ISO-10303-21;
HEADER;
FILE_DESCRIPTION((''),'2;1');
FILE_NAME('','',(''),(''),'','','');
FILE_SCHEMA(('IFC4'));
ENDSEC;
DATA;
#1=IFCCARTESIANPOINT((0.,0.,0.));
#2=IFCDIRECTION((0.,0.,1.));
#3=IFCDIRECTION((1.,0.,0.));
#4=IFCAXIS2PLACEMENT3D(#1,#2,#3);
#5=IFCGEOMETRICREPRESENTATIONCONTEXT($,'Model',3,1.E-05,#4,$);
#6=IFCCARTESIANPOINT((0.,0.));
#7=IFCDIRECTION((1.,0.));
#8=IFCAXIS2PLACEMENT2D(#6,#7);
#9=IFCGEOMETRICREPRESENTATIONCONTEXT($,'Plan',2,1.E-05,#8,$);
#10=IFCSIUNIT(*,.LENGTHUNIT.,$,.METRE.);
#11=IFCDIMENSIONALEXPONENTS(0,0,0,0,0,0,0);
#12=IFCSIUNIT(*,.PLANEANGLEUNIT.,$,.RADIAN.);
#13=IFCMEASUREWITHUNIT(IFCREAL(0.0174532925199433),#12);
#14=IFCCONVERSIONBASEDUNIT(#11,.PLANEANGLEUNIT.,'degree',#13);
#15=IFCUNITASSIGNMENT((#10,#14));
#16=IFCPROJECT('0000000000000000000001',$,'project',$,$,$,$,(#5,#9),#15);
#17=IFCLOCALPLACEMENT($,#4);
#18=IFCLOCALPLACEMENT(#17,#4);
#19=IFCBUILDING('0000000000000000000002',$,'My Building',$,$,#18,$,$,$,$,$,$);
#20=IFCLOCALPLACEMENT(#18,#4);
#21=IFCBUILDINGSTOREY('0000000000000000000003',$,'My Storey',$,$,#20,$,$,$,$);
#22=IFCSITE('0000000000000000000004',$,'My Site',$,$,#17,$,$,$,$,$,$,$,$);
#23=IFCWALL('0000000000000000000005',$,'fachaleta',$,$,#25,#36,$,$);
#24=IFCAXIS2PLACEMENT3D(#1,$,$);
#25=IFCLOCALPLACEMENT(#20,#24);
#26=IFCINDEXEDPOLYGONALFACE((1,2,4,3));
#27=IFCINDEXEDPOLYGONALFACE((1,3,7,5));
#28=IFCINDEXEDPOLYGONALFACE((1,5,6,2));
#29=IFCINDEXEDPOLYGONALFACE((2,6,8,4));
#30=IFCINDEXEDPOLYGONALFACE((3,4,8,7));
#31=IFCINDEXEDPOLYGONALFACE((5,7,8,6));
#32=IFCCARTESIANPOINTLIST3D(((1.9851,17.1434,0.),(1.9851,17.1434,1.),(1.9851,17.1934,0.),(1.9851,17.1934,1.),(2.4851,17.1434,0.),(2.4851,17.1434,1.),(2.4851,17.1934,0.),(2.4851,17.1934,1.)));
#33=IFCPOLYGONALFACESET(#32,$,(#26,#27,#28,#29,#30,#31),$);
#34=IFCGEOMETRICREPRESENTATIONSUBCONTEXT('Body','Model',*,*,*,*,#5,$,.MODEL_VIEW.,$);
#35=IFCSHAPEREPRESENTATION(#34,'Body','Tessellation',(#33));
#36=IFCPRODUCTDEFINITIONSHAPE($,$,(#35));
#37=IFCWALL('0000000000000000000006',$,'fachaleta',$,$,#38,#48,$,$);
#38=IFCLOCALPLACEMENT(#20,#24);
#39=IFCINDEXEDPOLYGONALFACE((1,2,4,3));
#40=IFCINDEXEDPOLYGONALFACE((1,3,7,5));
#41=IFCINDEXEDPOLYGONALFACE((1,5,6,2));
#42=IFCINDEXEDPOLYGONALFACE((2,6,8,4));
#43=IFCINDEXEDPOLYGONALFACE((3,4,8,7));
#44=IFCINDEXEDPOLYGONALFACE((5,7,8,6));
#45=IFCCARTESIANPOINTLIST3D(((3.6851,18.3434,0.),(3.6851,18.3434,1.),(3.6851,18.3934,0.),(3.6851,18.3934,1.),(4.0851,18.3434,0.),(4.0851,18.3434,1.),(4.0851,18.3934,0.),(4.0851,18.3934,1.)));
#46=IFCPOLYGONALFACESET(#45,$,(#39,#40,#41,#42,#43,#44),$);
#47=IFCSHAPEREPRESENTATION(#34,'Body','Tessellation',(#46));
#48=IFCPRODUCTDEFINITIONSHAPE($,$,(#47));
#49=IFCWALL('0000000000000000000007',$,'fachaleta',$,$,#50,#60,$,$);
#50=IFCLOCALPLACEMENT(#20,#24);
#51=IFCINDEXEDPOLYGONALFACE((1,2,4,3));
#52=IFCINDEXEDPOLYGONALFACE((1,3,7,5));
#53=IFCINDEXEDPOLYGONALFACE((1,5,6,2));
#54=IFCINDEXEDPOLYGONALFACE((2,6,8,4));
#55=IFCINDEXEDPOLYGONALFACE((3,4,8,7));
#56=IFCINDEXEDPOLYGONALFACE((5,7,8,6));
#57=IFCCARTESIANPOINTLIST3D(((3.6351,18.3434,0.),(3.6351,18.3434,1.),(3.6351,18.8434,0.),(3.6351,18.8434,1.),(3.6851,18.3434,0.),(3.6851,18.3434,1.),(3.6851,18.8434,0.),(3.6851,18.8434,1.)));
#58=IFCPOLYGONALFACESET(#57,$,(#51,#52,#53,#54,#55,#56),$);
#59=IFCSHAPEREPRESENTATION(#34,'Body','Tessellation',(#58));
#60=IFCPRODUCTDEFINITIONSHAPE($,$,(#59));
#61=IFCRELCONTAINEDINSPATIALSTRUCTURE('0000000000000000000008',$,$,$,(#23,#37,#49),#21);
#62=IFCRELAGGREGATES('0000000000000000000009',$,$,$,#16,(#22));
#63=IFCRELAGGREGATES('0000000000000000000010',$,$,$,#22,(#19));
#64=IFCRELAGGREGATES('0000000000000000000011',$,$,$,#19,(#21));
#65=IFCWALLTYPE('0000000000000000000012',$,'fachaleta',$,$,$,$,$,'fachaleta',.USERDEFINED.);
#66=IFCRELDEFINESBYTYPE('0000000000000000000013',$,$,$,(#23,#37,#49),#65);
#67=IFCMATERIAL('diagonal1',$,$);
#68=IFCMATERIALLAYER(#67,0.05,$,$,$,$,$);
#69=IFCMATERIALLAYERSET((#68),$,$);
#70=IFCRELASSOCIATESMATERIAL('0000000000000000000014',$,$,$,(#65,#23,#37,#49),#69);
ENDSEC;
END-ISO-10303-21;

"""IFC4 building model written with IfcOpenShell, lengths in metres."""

from ifc_helpers import new_model, entity, si_unit, converted_unit, frame, origin_with_axes, origin_2d_with_axis, place, context, subcontext, project, spatial, indexed_curve, outline, extrude, material, layer, layer_set, layer_usage, type_object, element, save


model = new_model("IFC4")

# Units and contexts
model_context = context("Model", 3, precision=1e-05, world=origin_with_axes())
plan_context = context("Plan", 2, precision=1e-05, world=origin_2d_with_axis())
body_context = subcontext(model_context, "Body", "Model", "MODEL_VIEW")
ifc_project = project(units=[si_unit("LENGTHUNIT", "METRE"), converted_unit("PLANEANGLEUNIT", "degree", entity("IfcReal", 0.0174532925199433), si_unit("PLANEANGLEUNIT", "RADIAN"), dimensions=[0, 0, 0, 0, 0, 0, 0])], contexts=[model_context, plan_context])

# Site, building, storey
site_placement = place(None, origin_with_axes())
site = spatial("IfcSite", under=ifc_project, at=site_placement, Name="My Site")
building_placement = place(site_placement, origin_with_axes())
building = spatial("IfcBuilding", under=site, at=building_placement, Name="My Building")
storey_placement = place(building_placement, origin_with_axes())
storey = spatial("IfcBuildingStorey", under=building, at=storey_placement, Name="My Storey")

# Walls
ifc_material_1 = material(Name="diagonal1")
ifc_layer = layer(ifc_material_1, 0.05)
ifc_layer_set = layer_set([ifc_layer])
wall_type = type_object("IfcWallType", Name="fachaleta", ElementType="fachaleta", PredefinedType="USERDEFINED", material=ifc_layer_set)
ifc_layer_usage_1 = layer_usage(ifc_layer_set, "AXIS2", "POSITIVE", 0.0)
wall_1_placement = place(storey_placement, frame((2.4851, 17.1934, 0.0), z_axis=(0.0, 0.0, 1.0), x_axis=(-1.0, 0.0, 0.0)))
element("IfcWall", 1, at=wall_1_placement, inside=storey, type_object=wall_type, material=ifc_layer_usage_1, Name="fachaleta", context=body_context, shape_type="SweptSolid", body=[
    extrude(outline(indexed_curve([(0.0, 0.0), (0.0, 0.05), (0.5, 0.05), (0.5, 0.0), (0.0, 0.0)], self_intersect=False)), origin_with_axes(), (0.0, 0.0, 1.0), 1.0),
])
ifc_layer_usage_2 = layer_usage(ifc_layer_set, "AXIS2", "POSITIVE", 0.0)
wall_2_placement = place(storey_placement, frame((3.6851, 18.3434, 0.0), z_axis=(0.0, 0.0, 1.0), x_axis=(1.0, 0.0, 0.0)))
element("IfcWall", 2, at=wall_2_placement, inside=storey, type_object=wall_type, material=ifc_layer_usage_2, Name="fachaleta", context=body_context, shape_type="SweptSolid", body=[
    extrude(outline(indexed_curve([(0.0, 0.0), (0.0, 0.05), (0.4, 0.05), (0.4, 0.0), (0.0, 0.0)], self_intersect=False)), origin_with_axes(), (0.0, 0.0, 1.0), 1.0),
])
ifc_layer_usage_3 = layer_usage(ifc_layer_set, "AXIS2", "POSITIVE", 0.0)
wall_3_placement = place(storey_placement, frame((3.6851, 18.3434, 0.0), z_axis=(0.0, 0.0, 1.0), x_axis=(0.000001, 1.0, 0.0)))
element("IfcWall", 3, at=wall_3_placement, inside=storey, type_object=wall_type, material=ifc_layer_usage_3, Name="fachaleta", context=body_context, shape_type="SweptSolid", body=[
    extrude(outline(indexed_curve([(0.0, 0.0), (0.0, 0.05), (0.5, 0.05), (0.5, 0.0), (0.0, 0.0)], self_intersect=False)), origin_with_axes(), (0.0, 0.0, 1.0), 1.0),
])

save(model, "model.ifc")
